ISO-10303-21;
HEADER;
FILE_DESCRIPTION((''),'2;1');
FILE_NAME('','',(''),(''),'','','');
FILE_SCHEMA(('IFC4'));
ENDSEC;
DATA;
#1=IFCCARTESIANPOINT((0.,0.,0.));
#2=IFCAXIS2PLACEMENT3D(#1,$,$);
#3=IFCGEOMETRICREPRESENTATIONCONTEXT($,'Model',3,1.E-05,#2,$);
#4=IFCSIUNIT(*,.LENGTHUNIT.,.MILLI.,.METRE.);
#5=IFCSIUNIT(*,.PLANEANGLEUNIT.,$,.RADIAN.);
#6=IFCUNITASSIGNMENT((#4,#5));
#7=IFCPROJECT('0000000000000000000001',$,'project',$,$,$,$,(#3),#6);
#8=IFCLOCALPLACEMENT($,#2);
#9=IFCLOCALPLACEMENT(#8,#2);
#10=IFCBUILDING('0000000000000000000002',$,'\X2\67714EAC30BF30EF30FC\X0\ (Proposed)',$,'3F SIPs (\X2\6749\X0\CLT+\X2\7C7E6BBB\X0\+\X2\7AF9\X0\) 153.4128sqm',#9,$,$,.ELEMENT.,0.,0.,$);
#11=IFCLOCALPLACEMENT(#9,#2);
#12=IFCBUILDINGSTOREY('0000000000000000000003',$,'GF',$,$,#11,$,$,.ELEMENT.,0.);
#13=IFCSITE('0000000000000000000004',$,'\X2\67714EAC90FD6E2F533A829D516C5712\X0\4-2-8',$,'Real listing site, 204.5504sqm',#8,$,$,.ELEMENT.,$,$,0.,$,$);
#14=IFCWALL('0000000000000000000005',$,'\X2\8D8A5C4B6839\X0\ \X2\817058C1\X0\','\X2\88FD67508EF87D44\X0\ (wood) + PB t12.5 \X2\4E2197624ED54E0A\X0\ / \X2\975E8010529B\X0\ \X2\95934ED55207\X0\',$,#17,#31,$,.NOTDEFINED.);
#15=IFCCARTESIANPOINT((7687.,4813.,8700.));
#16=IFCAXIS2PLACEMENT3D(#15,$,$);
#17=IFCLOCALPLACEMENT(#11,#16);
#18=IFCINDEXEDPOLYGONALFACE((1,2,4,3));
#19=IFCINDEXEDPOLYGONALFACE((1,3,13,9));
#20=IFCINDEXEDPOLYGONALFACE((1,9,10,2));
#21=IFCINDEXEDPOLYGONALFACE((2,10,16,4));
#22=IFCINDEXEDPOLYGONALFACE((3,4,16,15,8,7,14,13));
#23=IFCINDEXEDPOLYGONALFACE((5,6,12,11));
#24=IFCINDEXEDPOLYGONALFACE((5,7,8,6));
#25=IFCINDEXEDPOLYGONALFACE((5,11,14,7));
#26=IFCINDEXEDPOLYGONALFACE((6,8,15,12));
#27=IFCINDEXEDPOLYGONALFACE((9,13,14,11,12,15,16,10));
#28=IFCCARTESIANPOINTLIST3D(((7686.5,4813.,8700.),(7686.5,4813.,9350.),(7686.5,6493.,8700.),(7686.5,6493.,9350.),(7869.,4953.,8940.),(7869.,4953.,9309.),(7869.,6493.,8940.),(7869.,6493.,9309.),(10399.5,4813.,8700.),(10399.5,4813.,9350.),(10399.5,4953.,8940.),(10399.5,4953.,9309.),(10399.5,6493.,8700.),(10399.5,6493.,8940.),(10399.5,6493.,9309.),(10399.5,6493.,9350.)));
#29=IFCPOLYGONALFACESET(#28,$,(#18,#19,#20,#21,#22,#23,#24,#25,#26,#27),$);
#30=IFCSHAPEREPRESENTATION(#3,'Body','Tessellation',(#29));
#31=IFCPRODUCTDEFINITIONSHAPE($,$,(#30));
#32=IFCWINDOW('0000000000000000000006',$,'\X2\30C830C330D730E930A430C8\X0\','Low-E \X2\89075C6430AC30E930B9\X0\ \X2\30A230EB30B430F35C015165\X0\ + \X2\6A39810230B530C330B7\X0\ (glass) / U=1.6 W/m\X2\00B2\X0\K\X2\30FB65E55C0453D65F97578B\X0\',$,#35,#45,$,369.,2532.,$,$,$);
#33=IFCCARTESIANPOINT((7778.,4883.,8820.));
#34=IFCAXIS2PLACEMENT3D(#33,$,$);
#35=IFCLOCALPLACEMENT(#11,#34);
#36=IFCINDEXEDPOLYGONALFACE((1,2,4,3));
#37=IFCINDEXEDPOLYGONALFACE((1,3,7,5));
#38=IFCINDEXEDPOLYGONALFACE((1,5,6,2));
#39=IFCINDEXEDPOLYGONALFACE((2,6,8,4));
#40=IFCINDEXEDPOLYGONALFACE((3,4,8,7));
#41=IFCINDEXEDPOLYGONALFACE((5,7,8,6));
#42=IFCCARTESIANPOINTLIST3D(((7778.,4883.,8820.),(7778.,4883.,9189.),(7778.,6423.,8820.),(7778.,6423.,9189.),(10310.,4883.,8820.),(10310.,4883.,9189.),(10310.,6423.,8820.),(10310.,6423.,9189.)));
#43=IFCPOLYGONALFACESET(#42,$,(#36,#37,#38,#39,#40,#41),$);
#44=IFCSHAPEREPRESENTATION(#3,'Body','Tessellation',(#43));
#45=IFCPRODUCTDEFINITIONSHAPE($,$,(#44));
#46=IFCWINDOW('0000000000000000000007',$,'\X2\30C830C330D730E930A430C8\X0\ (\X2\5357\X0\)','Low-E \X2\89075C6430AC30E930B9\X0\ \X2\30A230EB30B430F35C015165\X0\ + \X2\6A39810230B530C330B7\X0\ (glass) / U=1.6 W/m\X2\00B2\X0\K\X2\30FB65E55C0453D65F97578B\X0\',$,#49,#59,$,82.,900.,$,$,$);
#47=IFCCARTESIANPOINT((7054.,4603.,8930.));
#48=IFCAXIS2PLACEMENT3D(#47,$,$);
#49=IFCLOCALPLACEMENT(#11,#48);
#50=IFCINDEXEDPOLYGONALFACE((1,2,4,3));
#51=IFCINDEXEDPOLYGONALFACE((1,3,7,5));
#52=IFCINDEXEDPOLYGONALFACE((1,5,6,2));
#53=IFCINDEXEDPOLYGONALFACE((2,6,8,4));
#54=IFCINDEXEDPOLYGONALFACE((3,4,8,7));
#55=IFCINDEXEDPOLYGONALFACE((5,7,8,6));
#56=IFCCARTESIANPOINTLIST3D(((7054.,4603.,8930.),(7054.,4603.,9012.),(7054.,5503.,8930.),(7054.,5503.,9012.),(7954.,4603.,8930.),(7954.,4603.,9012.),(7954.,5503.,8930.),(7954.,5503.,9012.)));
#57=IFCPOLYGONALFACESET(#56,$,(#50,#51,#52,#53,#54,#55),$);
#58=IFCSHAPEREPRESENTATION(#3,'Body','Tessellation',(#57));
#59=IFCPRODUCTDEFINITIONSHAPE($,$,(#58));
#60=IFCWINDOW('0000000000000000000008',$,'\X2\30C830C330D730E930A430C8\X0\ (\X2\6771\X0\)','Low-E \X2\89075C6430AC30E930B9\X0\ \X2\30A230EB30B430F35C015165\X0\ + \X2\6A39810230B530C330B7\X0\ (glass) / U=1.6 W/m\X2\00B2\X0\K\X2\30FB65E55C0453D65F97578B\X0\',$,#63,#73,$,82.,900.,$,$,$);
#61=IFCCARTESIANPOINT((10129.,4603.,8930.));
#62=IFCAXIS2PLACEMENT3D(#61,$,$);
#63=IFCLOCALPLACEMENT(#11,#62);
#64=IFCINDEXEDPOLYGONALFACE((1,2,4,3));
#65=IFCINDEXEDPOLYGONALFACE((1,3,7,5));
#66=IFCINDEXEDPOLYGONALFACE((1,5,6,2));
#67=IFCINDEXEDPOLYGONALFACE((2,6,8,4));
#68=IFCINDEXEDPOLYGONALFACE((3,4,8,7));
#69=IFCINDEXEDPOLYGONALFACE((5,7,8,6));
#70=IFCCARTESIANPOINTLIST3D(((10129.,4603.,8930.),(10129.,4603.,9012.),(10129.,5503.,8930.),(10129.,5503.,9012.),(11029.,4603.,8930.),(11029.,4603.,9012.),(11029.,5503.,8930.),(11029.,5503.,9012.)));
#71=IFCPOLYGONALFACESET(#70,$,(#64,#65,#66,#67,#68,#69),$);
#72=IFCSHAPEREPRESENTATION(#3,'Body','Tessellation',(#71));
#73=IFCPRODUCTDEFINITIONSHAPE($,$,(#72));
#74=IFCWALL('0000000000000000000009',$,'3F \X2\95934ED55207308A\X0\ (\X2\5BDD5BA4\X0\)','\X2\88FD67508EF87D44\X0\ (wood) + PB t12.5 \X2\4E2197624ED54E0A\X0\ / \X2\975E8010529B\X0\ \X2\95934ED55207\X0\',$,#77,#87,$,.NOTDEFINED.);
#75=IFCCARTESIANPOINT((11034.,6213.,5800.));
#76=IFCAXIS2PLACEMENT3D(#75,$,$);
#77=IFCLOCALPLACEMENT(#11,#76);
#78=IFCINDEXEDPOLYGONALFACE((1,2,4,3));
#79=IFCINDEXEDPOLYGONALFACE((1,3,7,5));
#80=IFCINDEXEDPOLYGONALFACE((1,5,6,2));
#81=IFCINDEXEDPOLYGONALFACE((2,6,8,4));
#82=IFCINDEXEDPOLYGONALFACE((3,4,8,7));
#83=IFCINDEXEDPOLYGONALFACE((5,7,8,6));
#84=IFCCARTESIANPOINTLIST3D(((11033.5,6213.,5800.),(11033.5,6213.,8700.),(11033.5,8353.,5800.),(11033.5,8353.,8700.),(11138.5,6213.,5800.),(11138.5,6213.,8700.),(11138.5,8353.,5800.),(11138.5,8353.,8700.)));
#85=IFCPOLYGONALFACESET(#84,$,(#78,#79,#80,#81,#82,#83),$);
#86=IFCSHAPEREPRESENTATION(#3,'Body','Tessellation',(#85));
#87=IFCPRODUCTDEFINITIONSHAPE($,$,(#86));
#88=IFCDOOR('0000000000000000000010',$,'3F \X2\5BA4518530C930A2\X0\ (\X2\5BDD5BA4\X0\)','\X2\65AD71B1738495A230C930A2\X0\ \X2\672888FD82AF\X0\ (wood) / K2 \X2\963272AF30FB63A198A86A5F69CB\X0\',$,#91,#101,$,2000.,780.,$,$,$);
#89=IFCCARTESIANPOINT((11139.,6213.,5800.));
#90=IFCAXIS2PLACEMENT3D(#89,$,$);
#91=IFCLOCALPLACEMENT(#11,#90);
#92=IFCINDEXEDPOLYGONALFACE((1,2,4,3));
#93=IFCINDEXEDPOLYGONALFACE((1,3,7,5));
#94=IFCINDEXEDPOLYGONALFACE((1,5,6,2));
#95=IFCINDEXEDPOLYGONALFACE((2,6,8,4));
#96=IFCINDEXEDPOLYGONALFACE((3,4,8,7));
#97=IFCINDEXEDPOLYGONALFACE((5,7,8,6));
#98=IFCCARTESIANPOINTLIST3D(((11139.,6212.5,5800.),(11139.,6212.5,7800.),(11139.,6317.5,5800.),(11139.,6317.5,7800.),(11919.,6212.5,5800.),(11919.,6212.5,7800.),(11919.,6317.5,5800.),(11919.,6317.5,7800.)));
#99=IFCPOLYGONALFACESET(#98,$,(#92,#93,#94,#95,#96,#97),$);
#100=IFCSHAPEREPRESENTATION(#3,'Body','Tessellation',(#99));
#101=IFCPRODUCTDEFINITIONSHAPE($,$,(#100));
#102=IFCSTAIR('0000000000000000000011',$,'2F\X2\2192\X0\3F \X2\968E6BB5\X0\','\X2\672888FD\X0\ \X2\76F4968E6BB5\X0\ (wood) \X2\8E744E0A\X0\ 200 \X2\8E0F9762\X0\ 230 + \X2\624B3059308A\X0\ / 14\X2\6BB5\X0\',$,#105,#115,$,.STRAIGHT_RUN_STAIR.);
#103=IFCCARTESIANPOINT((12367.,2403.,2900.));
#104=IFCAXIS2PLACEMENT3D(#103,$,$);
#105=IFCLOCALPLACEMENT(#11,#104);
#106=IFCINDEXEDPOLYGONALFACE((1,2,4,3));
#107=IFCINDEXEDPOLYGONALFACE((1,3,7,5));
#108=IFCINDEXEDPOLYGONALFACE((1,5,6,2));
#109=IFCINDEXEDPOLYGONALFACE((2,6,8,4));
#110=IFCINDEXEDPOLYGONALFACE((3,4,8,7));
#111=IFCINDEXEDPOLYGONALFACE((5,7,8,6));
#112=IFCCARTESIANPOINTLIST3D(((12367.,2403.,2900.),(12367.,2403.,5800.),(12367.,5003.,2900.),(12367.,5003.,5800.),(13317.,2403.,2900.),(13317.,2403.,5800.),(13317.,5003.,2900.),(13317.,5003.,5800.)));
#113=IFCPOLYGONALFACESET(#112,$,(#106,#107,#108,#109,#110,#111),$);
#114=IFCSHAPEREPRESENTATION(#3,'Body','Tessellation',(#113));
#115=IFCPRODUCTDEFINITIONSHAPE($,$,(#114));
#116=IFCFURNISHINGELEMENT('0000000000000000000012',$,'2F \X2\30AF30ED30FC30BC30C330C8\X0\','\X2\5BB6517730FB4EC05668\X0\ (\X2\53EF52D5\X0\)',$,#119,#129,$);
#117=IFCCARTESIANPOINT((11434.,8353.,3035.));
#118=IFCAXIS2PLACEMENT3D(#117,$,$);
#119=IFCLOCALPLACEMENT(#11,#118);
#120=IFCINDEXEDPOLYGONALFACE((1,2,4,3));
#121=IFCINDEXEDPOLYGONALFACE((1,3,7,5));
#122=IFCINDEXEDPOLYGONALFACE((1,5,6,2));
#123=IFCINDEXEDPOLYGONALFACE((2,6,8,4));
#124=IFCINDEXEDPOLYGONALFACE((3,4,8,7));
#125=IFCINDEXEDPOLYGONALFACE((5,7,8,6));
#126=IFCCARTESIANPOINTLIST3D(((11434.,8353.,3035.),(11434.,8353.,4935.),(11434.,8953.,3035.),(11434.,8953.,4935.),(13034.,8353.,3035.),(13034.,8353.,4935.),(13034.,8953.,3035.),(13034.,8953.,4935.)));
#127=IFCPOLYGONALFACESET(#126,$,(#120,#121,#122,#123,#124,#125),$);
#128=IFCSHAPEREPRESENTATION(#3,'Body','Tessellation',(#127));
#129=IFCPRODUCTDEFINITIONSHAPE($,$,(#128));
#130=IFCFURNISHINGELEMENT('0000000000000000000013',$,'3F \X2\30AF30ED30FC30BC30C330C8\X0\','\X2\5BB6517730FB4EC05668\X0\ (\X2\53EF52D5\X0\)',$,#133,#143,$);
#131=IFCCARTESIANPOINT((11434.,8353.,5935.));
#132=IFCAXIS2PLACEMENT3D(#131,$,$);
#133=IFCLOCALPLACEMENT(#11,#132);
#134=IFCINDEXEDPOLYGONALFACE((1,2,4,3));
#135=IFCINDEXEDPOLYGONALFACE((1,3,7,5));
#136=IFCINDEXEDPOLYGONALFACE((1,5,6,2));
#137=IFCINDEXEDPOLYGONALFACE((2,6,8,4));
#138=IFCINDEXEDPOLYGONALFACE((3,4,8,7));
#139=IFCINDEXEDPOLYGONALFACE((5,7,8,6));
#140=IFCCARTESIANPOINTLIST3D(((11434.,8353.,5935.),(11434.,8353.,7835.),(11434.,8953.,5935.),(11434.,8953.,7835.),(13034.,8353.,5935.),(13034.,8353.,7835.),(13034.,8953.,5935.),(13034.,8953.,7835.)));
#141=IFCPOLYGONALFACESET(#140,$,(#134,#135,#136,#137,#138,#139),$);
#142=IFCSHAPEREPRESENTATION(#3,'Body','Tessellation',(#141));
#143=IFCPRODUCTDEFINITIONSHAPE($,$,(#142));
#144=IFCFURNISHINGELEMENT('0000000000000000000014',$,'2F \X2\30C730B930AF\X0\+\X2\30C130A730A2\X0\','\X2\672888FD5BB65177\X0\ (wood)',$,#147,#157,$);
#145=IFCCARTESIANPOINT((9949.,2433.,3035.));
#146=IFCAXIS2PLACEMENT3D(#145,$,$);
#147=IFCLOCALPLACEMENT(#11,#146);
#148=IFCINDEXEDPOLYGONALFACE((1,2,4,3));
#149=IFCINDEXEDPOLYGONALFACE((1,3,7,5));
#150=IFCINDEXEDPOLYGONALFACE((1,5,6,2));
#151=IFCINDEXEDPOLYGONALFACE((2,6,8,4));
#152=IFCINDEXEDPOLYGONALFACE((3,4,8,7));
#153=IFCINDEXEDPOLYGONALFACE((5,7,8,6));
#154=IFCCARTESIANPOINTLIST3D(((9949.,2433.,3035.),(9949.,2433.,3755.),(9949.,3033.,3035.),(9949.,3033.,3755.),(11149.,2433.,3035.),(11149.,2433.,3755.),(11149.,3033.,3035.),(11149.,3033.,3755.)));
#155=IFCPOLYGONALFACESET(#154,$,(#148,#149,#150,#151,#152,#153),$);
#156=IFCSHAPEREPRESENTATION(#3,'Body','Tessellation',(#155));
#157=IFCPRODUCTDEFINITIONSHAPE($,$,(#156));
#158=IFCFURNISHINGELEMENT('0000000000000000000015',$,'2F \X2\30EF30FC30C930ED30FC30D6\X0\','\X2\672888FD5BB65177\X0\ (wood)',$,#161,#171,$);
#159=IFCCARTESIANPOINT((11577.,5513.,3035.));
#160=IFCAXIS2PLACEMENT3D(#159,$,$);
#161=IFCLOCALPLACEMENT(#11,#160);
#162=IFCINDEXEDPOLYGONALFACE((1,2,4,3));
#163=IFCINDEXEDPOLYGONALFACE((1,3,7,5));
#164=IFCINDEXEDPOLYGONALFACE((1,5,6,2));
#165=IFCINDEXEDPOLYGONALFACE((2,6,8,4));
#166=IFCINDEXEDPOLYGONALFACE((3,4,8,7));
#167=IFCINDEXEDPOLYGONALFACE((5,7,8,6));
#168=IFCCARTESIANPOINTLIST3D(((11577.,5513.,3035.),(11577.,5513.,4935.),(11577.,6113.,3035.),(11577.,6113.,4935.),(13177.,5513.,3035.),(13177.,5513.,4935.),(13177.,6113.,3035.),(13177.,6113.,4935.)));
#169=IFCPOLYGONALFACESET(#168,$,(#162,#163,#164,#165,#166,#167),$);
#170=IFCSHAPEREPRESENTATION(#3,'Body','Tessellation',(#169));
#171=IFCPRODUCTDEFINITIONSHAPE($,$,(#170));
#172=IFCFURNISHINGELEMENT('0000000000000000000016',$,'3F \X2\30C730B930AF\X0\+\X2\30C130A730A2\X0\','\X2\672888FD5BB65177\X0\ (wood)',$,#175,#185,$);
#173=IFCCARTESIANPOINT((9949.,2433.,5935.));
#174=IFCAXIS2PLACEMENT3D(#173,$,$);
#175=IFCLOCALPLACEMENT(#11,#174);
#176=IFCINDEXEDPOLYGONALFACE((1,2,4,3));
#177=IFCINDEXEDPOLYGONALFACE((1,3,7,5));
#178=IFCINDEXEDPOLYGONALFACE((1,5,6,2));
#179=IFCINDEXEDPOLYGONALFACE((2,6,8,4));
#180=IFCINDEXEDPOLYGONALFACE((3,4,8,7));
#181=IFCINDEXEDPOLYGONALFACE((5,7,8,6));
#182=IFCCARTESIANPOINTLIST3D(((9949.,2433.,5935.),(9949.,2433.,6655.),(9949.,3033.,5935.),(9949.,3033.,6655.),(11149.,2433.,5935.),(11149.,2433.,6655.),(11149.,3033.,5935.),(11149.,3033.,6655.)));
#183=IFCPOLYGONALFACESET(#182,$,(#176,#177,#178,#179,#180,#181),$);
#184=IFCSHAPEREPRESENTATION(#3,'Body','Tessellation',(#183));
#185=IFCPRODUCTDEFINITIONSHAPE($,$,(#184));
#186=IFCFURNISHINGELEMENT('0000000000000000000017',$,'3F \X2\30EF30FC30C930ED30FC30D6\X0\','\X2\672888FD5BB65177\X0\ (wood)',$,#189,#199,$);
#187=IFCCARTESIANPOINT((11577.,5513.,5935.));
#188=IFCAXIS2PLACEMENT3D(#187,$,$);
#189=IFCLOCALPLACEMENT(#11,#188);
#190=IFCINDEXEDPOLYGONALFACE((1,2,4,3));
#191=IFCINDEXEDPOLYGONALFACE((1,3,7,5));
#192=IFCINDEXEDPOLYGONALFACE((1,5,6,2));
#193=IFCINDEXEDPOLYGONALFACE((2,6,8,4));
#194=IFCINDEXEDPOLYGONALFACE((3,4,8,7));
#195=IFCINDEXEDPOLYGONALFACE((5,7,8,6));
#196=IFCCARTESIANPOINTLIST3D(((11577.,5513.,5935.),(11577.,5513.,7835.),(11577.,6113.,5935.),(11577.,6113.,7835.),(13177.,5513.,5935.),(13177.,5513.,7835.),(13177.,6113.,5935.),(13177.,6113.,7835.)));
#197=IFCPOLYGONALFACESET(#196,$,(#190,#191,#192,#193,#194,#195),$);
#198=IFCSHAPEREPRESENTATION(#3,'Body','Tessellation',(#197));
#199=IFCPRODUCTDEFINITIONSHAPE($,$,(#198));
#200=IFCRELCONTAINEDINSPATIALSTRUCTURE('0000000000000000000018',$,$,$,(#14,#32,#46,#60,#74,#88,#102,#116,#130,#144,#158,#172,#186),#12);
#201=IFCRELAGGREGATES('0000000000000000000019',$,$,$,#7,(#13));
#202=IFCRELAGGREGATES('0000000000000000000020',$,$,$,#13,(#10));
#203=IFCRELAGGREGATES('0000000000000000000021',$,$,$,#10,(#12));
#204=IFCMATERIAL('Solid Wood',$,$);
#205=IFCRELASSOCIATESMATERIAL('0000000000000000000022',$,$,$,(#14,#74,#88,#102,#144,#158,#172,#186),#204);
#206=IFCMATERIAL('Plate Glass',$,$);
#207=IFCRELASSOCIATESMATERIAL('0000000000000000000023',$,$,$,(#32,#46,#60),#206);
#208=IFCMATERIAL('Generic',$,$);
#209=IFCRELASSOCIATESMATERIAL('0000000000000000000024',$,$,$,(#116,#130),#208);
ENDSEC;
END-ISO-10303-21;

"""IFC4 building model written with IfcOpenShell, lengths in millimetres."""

from ifc_helpers import new_model, si_unit, frame, frame_2d, origin, place, context, project, spatial, rectangle, extrude, material, element, fill, save


model = new_model("IFC4")

# Units and contexts
model_context = context("Model", 3, precision=1e-05, world=origin())
ifc_project = project(units=[si_unit("LENGTHUNIT", "METRE", prefix="MILLI"), si_unit("PLANEANGLEUNIT", "RADIAN")], contexts=[model_context])

# Site, building, storey
site_placement = place(None, origin())
site = spatial("IfcSite", under=ifc_project, at=site_placement, Name="東京都港区芝公園4-2-8", ObjectType="Real listing site, 204.5504sqm", CompositionType="ELEMENT", RefElevation=0.0)
building_placement = place(site_placement, origin())
building = spatial("IfcBuilding", under=site, at=building_placement, Name="東京タワー (Proposed)", ObjectType="3F SIPs (杉CLT+籾殻+竹) 153.4128sqm", CompositionType="ELEMENT", ElevationOfRefHeight=0.0, ElevationOfTerrain=0.0)
storey_placement = place(building_placement, origin())
storey = spatial("IfcBuildingStorey", under=building, at=storey_placement, Name="GF", CompositionType="ELEMENT", Elevation=0.0)

# Shared definitions
ifc_material_1 = material(Name="Solid Wood")
ifc_material_2 = material(Name="Plate Glass")

# Wall, openings, windows
wall_1_placement = place(storey_placement, frame((7687.0, 4813.0, 8700.0)))
wall_1 = element("IfcWall", 1, at=wall_1_placement, inside=storey, material=ifc_material_1, Name="越屋根 腰壁", Description="製材軸組 (wood) + PB t12.5 両面仕上 / 非耐力 間仕切", PredefinedType="NOTDEFINED", context=model_context, shape_type="SweptSolid", body=[
    extrude(rectangle(XDim=2713.0, YDim=1680.0, at=frame_2d((1356.0, 840.0))), frame((7687.0, 4813.0, 8700.0)), (0.0, 0.0, 1.0), 650.0),
])
opening_1_placement = place(storey_placement, frame((7778.0, 4883.0, 8820.0)))
opening_1 = element("IfcOpeningElement", 2, at=opening_1_placement, cuts=wall_1, PredefinedType="NOTDEFINED", context=model_context, shape_type="SweptSolid", body=[
    extrude(rectangle(XDim=2532.0, YDim=1540.0, at=frame_2d((1266.0, 770.0))), frame((7778.0, 4883.0, 8820.0)), (0.0, 0.0, 1.0), 369.0),
])
opening_2_placement = place(storey_placement, frame((7054.0, 4603.0, 8930.0)))
opening_2 = element("IfcOpeningElement", 3, at=opening_2_placement, cuts=wall_1, PredefinedType="NOTDEFINED", context=model_context, shape_type="SweptSolid", body=[
    extrude(rectangle(XDim=900.0, YDim=900.0, at=frame_2d((450.0, 450.0))), frame((7054.0, 4603.0, 8930.0)), (0.0, 0.0, 1.0), 82.0),
])
opening_3_placement = place(storey_placement, frame((10129.0, 4603.0, 8930.0)))
opening_3 = element("IfcOpeningElement", 4, at=opening_3_placement, cuts=wall_1, PredefinedType="NOTDEFINED", context=model_context, shape_type="SweptSolid", body=[
    extrude(rectangle(XDim=900.0, YDim=900.0, at=frame_2d((450.0, 450.0))), frame((10129.0, 4603.0, 8930.0)), (0.0, 0.0, 1.0), 82.0),
])
window_1_placement = place(storey_placement, frame((7778.0, 4883.0, 8820.0)))
window_1 = element("IfcWindow", 5, at=window_1_placement, inside=storey, material=ifc_material_2, Name="トップライト", Description="Low-E 複層ガラス アルゴン封入 + 樹脂サッシ (glass) / U=1.6 W/m²K・日射取得型", OverallHeight=369.0, OverallWidth=2532.0, context=model_context, shape_type="SweptSolid", body=[
    extrude(rectangle(XDim=2532.0, YDim=1540.0, at=frame_2d((1266.0, 770.0))), frame((7778.0, 4883.0, 8820.0)), (0.0, 0.0, 1.0), 369.0),
])
fill(opening_1, window_1)
window_2_placement = place(storey_placement, frame((7054.0, 4603.0, 8930.0)))
window_2 = element("IfcWindow", 6, at=window_2_placement, inside=storey, material=ifc_material_2, Name="トップライト (南)", Description="Low-E 複層ガラス アルゴン封入 + 樹脂サッシ (glass) / U=1.6 W/m²K・日射取得型", OverallHeight=82.0, OverallWidth=900.0, context=model_context, shape_type="SweptSolid", body=[
    extrude(rectangle(XDim=900.0, YDim=900.0, at=frame_2d((450.0, 450.0))), frame((7054.0, 4603.0, 8930.0)), (0.0, 0.0, 1.0), 82.0),
])
fill(opening_2, window_2)
window_3_placement = place(storey_placement, frame((10129.0, 4603.0, 8930.0)))
window_3 = element("IfcWindow", 7, at=window_3_placement, inside=storey, material=ifc_material_2, Name="トップライト (東)", Description="Low-E 複層ガラス アルゴン封入 + 樹脂サッシ (glass) / U=1.6 W/m²K・日射取得型", OverallHeight=82.0, OverallWidth=900.0, context=model_context, shape_type="SweptSolid", body=[
    extrude(rectangle(XDim=900.0, YDim=900.0, at=frame_2d((450.0, 450.0))), frame((10129.0, 4603.0, 8930.0)), (0.0, 0.0, 1.0), 82.0),
])
fill(opening_3, window_3)

# Wall
wall_2_placement = place(storey_placement, frame((11034.0, 6213.0, 5800.0)))
element("IfcWall", 8, at=wall_2_placement, inside=storey, material=ifc_material_1, Name="3F 間仕切り (寝室)", Description="製材軸組 (wood) + PB t12.5 両面仕上 / 非耐力 間仕切", PredefinedType="NOTDEFINED", context=model_context, shape_type="SweptSolid", body=[
    extrude(rectangle(XDim=105.0, YDim=2140.0, at=frame_2d((52.0, 1070.0))), frame((11034.0, 6213.0, 5800.0)), (0.0, 0.0, 1.0), 2900.0),
])

# Door
door_1_placement = place(storey_placement, frame((11139.0, 6213.0, 5800.0)))
element("IfcDoor", 9, at=door_1_placement, inside=storey, material=ifc_material_1, Name="3F 室内ドア (寝室)", Description="断熱玄関ドア 木製芯 (wood) / K2 防犯・採風機構", OverallHeight=2000.0, OverallWidth=780.0, context=model_context, shape_type="SweptSolid", body=[
    extrude(rectangle(XDim=780.0, YDim=105.0, at=frame_2d((390.0, 52.0))), frame((11139.0, 6213.0, 5800.0)), (0.0, 0.0, 1.0), 2000.0),
])

# Stair
stair_placement = place(storey_placement, frame((12367.0, 2403.0, 2900.0)))
element("IfcStair", 10, at=stair_placement, inside=storey, material=ifc_material_1, Name="2F→3F 階段", Description="木製 直階段 (wood) 蹴上 200 踏面 230 + 手すり / 14段", PredefinedType="STRAIGHT_RUN_STAIR", context=model_context, shape_type="SweptSolid", body=[
    extrude(rectangle(XDim=950.0, YDim=2600.0, at=frame_2d((475.0, 1300.0))), frame((12367.0, 2403.0, 2900.0)), (0.0, 0.0, 1.0), 2900.0),
])

# Furnishing elements
ifc_material_3 = material(Name="Generic")
furnishing_1_placement = place(storey_placement, frame((11434.0, 8353.0, 3035.0)))
element("IfcFurnishingElement", 11, at=furnishing_1_placement, inside=storey, material=ifc_material_3, Name="2F クローゼット", Description="家具・什器 (可動)", context=model_context, shape_type="SweptSolid", body=[
    extrude(rectangle(XDim=1600.0, YDim=600.0, at=frame_2d((800.0, 300.0))), frame((11434.0, 8353.0, 3035.0)), (0.0, 0.0, 1.0), 1900.0),
])
furnishing_2_placement = place(storey_placement, frame((11434.0, 8353.0, 5935.0)))
element("IfcFurnishingElement", 12, at=furnishing_2_placement, inside=storey, material=ifc_material_3, Name="3F クローゼット", Description="家具・什器 (可動)", context=model_context, shape_type="SweptSolid", body=[
    extrude(rectangle(XDim=1600.0, YDim=600.0, at=frame_2d((800.0, 300.0))), frame((11434.0, 8353.0, 5935.0)), (0.0, 0.0, 1.0), 1900.0),
])
furnishing_3_placement = place(storey_placement, frame((9949.0, 2433.0, 3035.0)))
element("IfcFurnishingElement", 13, at=furnishing_3_placement, inside=storey, material=ifc_material_1, Name="2F デスク+チェア", Description="木製家具 (wood)", context=model_context, shape_type="SweptSolid", body=[
    extrude(rectangle(XDim=1200.0, YDim=600.0, at=frame_2d((600.0, 300.0))), frame((9949.0, 2433.0, 3035.0)), (0.0, 0.0, 1.0), 720.0),
])
furnishing_4_placement = place(storey_placement, frame((11577.0, 5513.0, 3035.0)))
element("IfcFurnishingElement", 14, at=furnishing_4_placement, inside=storey, material=ifc_material_1, Name="2F ワードローブ", Description="木製家具 (wood)", context=model_context, shape_type="SweptSolid", body=[
    extrude(rectangle(XDim=1600.0, YDim=600.0, at=frame_2d((800.0, 300.0))), frame((11577.0, 5513.0, 3035.0)), (0.0, 0.0, 1.0), 1900.0),
])
furnishing_5_placement = place(storey_placement, frame((9949.0, 2433.0, 5935.0)))
element("IfcFurnishingElement", 15, at=furnishing_5_placement, inside=storey, material=ifc_material_1, Name="3F デスク+チェア", Description="木製家具 (wood)", context=model_context, shape_type="SweptSolid", body=[
    extrude(rectangle(XDim=1200.0, YDim=600.0, at=frame_2d((600.0, 300.0))), frame((9949.0, 2433.0, 5935.0)), (0.0, 0.0, 1.0), 720.0),
])
furnishing_6_placement = place(storey_placement, frame((11577.0, 5513.0, 5935.0)))
element("IfcFurnishingElement", 16, at=furnishing_6_placement, inside=storey, material=ifc_material_1, Name="3F ワードローブ", Description="木製家具 (wood)", context=model_context, shape_type="SweptSolid", body=[
    extrude(rectangle(XDim=1600.0, YDim=600.0, at=frame_2d((800.0, 300.0))), frame((11577.0, 5513.0, 5935.0)), (0.0, 0.0, 1.0), 1900.0),
])

save(model, "model.ifc")
